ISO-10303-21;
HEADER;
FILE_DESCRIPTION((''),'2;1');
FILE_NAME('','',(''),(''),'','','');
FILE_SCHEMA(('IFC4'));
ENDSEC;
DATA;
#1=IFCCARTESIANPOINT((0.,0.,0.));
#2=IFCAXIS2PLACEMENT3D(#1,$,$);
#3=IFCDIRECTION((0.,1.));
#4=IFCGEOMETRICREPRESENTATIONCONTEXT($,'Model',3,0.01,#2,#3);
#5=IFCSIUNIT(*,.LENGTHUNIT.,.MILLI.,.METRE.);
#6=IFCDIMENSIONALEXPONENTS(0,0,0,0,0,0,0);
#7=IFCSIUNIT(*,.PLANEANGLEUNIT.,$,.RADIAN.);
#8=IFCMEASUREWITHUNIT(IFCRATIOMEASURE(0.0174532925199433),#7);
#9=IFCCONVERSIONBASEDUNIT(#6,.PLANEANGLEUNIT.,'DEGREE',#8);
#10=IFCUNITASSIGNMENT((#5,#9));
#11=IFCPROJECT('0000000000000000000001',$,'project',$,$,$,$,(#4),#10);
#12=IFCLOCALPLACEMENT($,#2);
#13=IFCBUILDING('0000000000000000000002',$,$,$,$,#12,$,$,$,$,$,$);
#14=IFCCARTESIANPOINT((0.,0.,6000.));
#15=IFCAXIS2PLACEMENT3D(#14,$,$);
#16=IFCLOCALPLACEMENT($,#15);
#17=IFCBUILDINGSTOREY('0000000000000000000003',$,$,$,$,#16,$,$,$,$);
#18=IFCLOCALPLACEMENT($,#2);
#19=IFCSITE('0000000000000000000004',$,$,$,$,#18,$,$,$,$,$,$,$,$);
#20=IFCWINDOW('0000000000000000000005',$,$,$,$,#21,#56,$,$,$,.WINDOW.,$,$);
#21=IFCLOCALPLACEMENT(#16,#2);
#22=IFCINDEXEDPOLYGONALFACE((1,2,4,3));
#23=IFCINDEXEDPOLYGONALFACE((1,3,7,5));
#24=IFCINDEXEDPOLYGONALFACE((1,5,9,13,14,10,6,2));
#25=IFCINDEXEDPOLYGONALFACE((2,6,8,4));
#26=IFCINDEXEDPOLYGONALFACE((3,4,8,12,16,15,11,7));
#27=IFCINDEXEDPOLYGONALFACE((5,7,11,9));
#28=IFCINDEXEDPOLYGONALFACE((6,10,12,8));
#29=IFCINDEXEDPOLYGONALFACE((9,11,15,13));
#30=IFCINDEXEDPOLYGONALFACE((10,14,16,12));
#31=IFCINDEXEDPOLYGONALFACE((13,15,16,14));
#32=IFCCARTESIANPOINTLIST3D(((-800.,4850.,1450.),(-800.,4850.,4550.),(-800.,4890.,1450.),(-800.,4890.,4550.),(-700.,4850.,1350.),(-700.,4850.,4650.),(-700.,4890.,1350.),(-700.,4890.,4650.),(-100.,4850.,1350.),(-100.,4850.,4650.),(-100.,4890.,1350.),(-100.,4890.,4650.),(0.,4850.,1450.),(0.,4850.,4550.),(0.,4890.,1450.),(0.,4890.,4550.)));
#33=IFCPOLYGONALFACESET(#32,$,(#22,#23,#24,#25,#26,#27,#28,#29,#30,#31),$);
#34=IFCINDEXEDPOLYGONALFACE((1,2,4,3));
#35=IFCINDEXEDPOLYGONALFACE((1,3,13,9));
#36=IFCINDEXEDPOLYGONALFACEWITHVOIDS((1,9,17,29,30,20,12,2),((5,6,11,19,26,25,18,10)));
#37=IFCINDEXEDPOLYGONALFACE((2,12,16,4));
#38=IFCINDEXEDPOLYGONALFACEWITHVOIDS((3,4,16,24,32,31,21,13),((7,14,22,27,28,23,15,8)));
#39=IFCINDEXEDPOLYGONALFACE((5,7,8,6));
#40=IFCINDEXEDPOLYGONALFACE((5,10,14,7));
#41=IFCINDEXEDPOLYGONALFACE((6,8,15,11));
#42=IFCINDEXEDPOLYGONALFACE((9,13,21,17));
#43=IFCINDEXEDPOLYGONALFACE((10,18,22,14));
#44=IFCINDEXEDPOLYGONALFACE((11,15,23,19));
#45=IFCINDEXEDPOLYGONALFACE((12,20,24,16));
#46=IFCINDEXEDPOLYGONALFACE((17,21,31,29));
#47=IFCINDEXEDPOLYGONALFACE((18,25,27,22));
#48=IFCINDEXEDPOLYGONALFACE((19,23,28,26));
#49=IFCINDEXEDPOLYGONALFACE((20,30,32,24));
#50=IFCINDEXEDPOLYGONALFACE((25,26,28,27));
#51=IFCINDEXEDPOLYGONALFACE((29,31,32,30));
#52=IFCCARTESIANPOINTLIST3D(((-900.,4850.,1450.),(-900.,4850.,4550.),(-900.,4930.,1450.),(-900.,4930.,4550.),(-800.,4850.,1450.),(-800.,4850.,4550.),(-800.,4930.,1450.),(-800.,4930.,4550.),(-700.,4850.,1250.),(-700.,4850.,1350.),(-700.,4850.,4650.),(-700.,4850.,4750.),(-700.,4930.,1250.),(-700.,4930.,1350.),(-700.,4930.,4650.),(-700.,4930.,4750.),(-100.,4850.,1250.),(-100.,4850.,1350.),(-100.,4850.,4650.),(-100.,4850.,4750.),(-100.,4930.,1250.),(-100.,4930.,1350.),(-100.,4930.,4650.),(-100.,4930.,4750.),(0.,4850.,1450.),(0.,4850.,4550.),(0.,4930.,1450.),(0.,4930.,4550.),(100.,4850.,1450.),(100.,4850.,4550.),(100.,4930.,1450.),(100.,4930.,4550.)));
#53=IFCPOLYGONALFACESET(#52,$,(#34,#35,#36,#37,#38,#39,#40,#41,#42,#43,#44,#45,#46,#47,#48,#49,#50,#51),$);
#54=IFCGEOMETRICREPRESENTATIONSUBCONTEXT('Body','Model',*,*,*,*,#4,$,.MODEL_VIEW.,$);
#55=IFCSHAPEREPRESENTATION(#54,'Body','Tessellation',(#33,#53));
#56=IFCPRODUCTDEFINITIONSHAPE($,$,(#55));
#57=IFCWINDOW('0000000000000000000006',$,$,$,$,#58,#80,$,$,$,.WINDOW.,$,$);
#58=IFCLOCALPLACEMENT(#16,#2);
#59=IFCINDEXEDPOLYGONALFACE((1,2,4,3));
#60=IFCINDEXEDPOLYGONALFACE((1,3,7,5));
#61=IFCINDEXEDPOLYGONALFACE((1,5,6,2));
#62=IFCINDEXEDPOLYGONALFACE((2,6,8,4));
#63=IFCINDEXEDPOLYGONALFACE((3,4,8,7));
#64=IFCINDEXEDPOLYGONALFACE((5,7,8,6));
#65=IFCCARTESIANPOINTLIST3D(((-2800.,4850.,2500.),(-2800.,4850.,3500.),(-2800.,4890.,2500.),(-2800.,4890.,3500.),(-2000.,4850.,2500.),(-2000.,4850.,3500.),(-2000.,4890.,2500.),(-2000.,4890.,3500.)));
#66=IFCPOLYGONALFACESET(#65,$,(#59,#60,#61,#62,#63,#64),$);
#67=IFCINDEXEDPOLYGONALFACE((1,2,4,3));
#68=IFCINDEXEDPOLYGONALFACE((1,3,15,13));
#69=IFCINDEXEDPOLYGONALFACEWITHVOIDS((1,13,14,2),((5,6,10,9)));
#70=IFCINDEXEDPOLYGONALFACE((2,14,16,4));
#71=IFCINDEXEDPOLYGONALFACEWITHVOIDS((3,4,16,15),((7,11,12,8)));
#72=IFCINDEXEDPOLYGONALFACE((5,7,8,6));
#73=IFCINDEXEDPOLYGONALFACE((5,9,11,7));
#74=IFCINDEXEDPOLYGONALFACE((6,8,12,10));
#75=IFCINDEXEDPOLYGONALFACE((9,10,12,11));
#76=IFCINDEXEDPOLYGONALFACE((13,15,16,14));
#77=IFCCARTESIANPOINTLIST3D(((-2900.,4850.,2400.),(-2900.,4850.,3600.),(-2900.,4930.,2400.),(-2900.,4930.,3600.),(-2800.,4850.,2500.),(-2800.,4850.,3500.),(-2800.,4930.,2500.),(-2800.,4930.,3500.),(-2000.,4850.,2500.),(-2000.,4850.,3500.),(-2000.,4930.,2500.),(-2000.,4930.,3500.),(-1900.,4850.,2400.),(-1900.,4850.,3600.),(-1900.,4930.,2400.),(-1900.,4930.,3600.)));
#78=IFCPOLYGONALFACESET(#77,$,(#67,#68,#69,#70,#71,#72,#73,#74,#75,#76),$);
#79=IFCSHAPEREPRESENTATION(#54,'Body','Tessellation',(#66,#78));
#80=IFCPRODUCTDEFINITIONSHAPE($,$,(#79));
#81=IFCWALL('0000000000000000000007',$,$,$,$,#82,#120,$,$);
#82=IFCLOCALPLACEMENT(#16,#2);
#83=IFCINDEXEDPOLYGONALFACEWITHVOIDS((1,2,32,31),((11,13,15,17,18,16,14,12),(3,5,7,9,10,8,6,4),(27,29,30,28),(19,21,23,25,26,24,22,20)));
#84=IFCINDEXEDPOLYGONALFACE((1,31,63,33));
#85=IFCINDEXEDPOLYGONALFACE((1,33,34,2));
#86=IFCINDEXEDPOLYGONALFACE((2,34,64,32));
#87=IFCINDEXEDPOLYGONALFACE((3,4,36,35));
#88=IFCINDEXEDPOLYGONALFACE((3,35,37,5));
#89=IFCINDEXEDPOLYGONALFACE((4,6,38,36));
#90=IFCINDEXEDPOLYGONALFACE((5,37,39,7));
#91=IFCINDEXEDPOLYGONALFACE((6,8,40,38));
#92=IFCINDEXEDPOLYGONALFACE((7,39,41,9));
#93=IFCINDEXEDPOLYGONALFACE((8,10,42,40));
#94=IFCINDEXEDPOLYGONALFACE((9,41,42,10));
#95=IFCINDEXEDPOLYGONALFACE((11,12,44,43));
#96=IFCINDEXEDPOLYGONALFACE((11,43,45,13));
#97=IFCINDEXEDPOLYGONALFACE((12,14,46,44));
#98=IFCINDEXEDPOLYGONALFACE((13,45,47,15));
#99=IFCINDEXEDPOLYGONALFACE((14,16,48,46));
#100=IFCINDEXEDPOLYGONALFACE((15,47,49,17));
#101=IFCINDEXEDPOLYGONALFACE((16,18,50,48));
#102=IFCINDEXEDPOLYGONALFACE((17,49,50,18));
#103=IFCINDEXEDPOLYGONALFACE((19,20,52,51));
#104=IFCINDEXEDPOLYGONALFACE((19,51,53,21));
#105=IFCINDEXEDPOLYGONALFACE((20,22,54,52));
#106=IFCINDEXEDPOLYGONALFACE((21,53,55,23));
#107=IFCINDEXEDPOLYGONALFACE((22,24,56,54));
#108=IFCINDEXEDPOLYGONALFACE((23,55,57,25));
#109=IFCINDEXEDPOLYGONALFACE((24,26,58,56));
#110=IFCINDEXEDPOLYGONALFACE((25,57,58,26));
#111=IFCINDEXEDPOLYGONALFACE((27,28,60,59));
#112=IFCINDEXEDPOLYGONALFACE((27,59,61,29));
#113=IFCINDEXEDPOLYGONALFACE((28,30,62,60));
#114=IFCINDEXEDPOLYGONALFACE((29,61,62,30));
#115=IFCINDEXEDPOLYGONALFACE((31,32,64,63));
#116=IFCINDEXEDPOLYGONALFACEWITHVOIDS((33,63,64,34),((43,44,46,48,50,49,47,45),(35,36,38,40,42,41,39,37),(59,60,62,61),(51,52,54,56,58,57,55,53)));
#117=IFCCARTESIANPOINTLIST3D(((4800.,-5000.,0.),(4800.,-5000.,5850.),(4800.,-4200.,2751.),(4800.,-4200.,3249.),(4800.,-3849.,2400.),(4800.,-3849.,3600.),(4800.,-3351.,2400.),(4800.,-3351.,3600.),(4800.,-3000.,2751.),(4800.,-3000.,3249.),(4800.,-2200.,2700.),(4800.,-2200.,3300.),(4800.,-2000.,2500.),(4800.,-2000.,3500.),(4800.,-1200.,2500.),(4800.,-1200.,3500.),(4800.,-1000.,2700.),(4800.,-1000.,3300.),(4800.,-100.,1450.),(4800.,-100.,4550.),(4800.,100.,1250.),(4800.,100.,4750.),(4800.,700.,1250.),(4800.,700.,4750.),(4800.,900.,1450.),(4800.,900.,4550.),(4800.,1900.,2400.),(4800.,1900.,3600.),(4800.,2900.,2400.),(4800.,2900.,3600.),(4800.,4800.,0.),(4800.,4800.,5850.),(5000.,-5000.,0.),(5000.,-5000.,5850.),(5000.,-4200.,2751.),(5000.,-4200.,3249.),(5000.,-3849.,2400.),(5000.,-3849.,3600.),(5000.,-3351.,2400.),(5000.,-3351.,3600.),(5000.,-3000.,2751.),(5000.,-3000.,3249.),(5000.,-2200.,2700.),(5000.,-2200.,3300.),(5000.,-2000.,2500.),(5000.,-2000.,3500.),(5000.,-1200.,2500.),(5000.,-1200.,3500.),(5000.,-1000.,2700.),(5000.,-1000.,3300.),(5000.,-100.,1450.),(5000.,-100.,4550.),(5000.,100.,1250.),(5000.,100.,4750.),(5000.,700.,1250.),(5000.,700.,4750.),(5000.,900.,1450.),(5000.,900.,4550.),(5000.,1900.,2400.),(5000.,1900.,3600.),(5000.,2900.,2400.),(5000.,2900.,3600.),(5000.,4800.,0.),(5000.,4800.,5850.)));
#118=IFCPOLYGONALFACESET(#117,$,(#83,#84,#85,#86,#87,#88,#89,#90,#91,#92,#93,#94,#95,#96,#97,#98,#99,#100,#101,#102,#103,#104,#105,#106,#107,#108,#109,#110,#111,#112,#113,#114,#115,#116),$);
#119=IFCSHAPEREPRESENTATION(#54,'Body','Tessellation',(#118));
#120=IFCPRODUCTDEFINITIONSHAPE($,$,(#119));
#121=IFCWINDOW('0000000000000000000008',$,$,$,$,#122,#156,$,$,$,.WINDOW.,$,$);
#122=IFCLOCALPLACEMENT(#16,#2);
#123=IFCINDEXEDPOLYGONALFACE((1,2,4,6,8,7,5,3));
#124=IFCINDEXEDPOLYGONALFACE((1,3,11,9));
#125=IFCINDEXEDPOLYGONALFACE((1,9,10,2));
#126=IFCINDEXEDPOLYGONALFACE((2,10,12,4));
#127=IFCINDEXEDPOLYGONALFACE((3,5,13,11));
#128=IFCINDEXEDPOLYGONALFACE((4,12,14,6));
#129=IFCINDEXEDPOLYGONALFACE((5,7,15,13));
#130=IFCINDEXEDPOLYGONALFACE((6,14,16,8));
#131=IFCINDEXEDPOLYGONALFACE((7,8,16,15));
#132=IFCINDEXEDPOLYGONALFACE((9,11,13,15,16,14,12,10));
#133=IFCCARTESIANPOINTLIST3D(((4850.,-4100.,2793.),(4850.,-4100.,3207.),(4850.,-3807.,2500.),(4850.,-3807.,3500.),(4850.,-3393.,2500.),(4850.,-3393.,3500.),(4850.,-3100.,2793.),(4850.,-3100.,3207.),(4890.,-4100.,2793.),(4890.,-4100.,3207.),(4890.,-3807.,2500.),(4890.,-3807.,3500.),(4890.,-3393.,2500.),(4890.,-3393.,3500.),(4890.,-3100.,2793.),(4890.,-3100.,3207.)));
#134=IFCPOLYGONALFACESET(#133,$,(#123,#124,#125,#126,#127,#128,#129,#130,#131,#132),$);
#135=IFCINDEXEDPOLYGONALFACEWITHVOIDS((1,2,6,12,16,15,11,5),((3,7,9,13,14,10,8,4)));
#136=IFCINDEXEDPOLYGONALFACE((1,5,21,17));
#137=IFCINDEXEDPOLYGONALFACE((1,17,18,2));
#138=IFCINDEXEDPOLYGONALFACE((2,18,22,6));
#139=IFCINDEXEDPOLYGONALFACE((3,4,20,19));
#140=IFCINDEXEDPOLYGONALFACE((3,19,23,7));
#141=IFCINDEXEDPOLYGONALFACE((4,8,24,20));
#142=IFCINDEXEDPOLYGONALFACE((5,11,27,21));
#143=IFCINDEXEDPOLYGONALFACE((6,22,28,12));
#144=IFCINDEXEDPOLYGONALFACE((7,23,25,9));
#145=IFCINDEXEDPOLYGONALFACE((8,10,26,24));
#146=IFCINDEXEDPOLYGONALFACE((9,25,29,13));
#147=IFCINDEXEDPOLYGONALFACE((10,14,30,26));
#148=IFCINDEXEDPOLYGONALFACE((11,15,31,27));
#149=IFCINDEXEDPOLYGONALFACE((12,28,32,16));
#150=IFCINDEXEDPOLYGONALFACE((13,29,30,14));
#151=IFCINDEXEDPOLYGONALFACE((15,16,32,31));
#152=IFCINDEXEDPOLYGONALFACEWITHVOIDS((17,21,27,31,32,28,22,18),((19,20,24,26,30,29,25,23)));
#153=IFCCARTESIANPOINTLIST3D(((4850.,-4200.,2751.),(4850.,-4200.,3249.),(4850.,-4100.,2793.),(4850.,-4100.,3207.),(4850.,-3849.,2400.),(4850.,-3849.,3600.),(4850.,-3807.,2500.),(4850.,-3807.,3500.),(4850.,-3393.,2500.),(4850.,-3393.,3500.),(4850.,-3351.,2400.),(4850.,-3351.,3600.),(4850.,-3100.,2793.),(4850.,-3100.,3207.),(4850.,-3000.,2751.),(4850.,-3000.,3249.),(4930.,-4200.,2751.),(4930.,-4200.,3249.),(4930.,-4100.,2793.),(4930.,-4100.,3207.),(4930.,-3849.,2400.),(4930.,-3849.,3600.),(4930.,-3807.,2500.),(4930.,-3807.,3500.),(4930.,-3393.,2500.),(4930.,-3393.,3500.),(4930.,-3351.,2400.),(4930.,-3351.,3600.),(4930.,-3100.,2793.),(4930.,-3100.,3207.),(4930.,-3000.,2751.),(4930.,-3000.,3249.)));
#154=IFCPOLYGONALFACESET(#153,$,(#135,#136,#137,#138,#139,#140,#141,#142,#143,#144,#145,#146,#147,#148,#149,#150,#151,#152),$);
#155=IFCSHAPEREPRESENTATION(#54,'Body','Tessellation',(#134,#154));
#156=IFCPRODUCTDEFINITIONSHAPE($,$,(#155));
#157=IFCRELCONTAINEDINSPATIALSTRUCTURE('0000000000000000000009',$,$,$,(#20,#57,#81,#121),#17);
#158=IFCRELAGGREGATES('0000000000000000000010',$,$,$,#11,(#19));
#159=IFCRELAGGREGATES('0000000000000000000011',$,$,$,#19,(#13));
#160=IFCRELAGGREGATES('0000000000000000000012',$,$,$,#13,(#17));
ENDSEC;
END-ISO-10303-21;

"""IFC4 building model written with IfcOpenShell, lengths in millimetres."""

from ifc_helpers import new_model, entity, si_unit, converted_unit, direction, frame, origin, origin_2d, place, context, subcontext, project, spatial, polyline, rectangle, outline, extrude, element, save


model = new_model("IFC4")

# Units and contexts
model_context = context("Model", 3, precision=0.01, world=origin(), true_north=direction((0.0, 1.0)))
body_context = subcontext(model_context, "Body", "Model", "MODEL_VIEW")
ifc_project = project(units=[si_unit("LENGTHUNIT", "METRE", prefix="MILLI"), converted_unit("PLANEANGLEUNIT", "DEGREE", entity("IfcRatioMeasure", 0.0174532925199433), si_unit("PLANEANGLEUNIT", "RADIAN"), dimensions=[0, 0, 0, 0, 0, 0, 0])], contexts=[model_context])

# Site, building, storey
site_placement = place(None, origin())
site = spatial("IfcSite", under=ifc_project, at=site_placement)
building_placement = place(None, origin())
building = spatial("IfcBuilding", under=site, at=building_placement)
storey_placement = place(None, frame((0.0, 0.0, 6000.0)))
storey = spatial("IfcBuildingStorey", under=building, at=storey_placement)

# Shared definitions
wall_1_placement = place(storey_placement, frame((100.0, 4900.0, 0.0), z_axis=(0.0, 0.0, 1.0), x_axis=(-1.0, 0.0, 0.0)))
window_1_placement = place(wall_1_placement, frame((500.0, 50.0, 3000.0)))
window_2_placement = place(wall_1_placement, frame((2500.0, 50.0, 3000.0)))

# Windows
cartesian_point_1 = entity("IfcCartesianPoint", [-500.0, -207.0])
shared_polyline_1 = entity("IfcPolyline", [cartesian_point_1, entity("IfcCartesianPoint", [-500.0, 207.0]), entity("IfcCartesianPoint", [-207.0, 500.0]), entity("IfcCartesianPoint", [207.0, 500.0]), entity("IfcCartesianPoint", [500.0, 207.0]), entity("IfcCartesianPoint", [500.0, -207.0]), entity("IfcCartesianPoint", [207.0, -500.0]), entity("IfcCartesianPoint", [-207.0, -500.0]), cartesian_point_1])
cartesian_point_2 = entity("IfcCartesianPoint", [-400.0, -1550.0])
shared_polyline_2 = entity("IfcPolyline", [cartesian_point_2, entity("IfcCartesianPoint", [-400.0, 1550.0]), entity("IfcCartesianPoint", [-300.0, 1650.0]), entity("IfcCartesianPoint", [300.0, 1650.0]), entity("IfcCartesianPoint", [400.0, 1550.0]), entity("IfcCartesianPoint", [400.0, -1550.0]), entity("IfcCartesianPoint", [300.0, -1650.0]), entity("IfcCartesianPoint", [-300.0, -1650.0]), cartesian_point_2])
cartesian_point_3 = entity("IfcCartesianPoint", [-500.0, -1550.0])
element("IfcWindow", 1, at=window_1_placement, inside=storey, PredefinedType="WINDOW", context=body_context, shape_type="SweptSolid", body=[
    entity("IfcExtrudedAreaSolid", entity("IfcArbitraryClosedProfileDef", "AREA", None, shared_polyline_2), entity("IfcAxis2Placement3D", entity("IfcCartesianPoint", [0.0, 0.0, 0.0]), entity("IfcDirection", [0.0, -1.0, 0.0]), entity("IfcDirection", [1.0, 0.0, 0.0])), entity("IfcDirection", [0.0, 0.0, 1.0]), 40.0),
    entity("IfcExtrudedAreaSolid", entity("IfcArbitraryProfileDefWithVoids", "AREA", None, entity("IfcPolyline", [cartesian_point_3, entity("IfcCartesianPoint", [-500.0, 1550.0]), entity("IfcCartesianPoint", [-300.0, 1750.0]), entity("IfcCartesianPoint", [300.0, 1750.0]), entity("IfcCartesianPoint", [500.0, 1550.0]), entity("IfcCartesianPoint", [500.0, -1550.0]), entity("IfcCartesianPoint", [300.0, -1750.0]), entity("IfcCartesianPoint", [-300.0, -1750.0]), cartesian_point_3]), [shared_polyline_2]), entity("IfcAxis2Placement3D", entity("IfcCartesianPoint", [0.0, 0.0, 0.0]), entity("IfcDirection", [0.0, -1.0, 0.0]), entity("IfcDirection", [1.0, 0.0, 0.0])), entity("IfcDirection", [0.0, 0.0, 1.0]), 80.0),
])
cartesian_point_4 = entity("IfcCartesianPoint", [-400.0, -500.0])
shared_polyline_3 = entity("IfcPolyline", [cartesian_point_4, entity("IfcCartesianPoint", [-400.0, 500.0]), entity("IfcCartesianPoint", [-400.0, 500.0]), entity("IfcCartesianPoint", [400.0, 500.0]), entity("IfcCartesianPoint", [400.0, 500.0]), entity("IfcCartesianPoint", [400.0, -500.0]), entity("IfcCartesianPoint", [400.0, -500.0]), entity("IfcCartesianPoint", [-400.0, -500.0]), cartesian_point_4])
cartesian_point_5 = entity("IfcCartesianPoint", [-500.0, -600.0])
element("IfcWindow", 2, at=window_2_placement, inside=storey, PredefinedType="WINDOW", context=body_context, shape_type="SweptSolid", body=[
    entity("IfcExtrudedAreaSolid", entity("IfcArbitraryClosedProfileDef", "AREA", None, shared_polyline_3), entity("IfcAxis2Placement3D", entity("IfcCartesianPoint", [0.0, 0.0, 0.0]), entity("IfcDirection", [0.0, -1.0, 0.0]), entity("IfcDirection", [1.0, 0.0, 0.0])), entity("IfcDirection", [0.0, 0.0, 1.0]), 40.0),
    entity("IfcExtrudedAreaSolid", entity("IfcArbitraryProfileDefWithVoids", "AREA", None, entity("IfcPolyline", [cartesian_point_5, entity("IfcCartesianPoint", [-500.0, 600.0]), entity("IfcCartesianPoint", [-500.0, 600.0]), entity("IfcCartesianPoint", [500.0, 600.0]), entity("IfcCartesianPoint", [500.0, 600.0]), entity("IfcCartesianPoint", [500.0, -600.0]), entity("IfcCartesianPoint", [500.0, -600.0]), entity("IfcCartesianPoint", [-500.0, -600.0]), cartesian_point_5]), [shared_polyline_3]), entity("IfcAxis2Placement3D", entity("IfcCartesianPoint", [0.0, 0.0, 0.0]), entity("IfcDirection", [0.0, -1.0, 0.0]), entity("IfcDirection", [1.0, 0.0, 0.0])), entity("IfcDirection", [0.0, 0.0, 1.0]), 80.0),
])

# Wall, openings
wall_2_placement = place(storey_placement, frame((4900.0, -100.0, 0.0), z_axis=(0.0, 0.0, 1.0), x_axis=(0.0, 1.0, 0.0)))
wall_2 = element("IfcWall", 3, at=wall_2_placement, inside=storey, context=body_context, shape_type="SweptSolid", body=[
    extrude(rectangle(XDim=9800.0, YDim=200.0, at=origin_2d()), origin(), (0.0, 0.0, 1.0), 5850.0),
])
window_3_placement = place(wall_2_placement, frame((-3500.0, 50.0, 3000.0)))
opening_1_placement = place(window_3_placement, frame((0.0, 50.0, 0.0)))
element("IfcOpeningElement", 4, at=opening_1_placement, cuts=wall_2, context=body_context, shape_type="SweptSolid", body=[
    extrude(outline(polyline([(-600.0, -249.0), (-600.0, 249.0), (-249.0, 600.0), (249.0, 600.0), (600.0, 249.0), (600.0, -249.0), (249.0, -600.0), (-249.0, -600.0), (-600.0, -249.0)])), frame((0.0, 0.0, 0.0), z_axis=(0.0, -1.0, 0.0), x_axis=(1.0, 0.0, 0.0)), (0.0, 0.0, 1.0), 200.0),
])
window_4_placement = place(wall_2_placement, frame((-1500.0, 50.0, 3000.0)))
opening_2_placement = place(window_4_placement, frame((0.0, 50.0, 0.0)))
element("IfcOpeningElement", 5, at=opening_2_placement, cuts=wall_2, context=body_context, shape_type="SweptSolid", body=[
    extrude(outline(polyline([(-600.0, -300.0), (-600.0, 300.0), (-400.0, 500.0), (400.0, 500.0), (600.0, 300.0), (600.0, -300.0), (400.0, -500.0), (-400.0, -500.0), (-600.0, -300.0)])), frame((0.0, 0.0, 0.0), z_axis=(0.0, -1.0, 0.0), x_axis=(1.0, 0.0, 0.0)), (0.0, 0.0, 1.0), 200.0),
])
window_5_placement = place(wall_2_placement, frame((500.0, 50.0, 3000.0)))
opening_3_placement = place(window_5_placement, frame((0.0, 50.0, 0.0)))
element("IfcOpeningElement", 6, at=opening_3_placement, cuts=wall_2, context=body_context, shape_type="SweptSolid", body=[
    extrude(outline(polyline([(-500.0, -1550.0), (-500.0, 1550.0), (-300.0, 1750.0), (300.0, 1750.0), (500.0, 1550.0), (500.0, -1550.0), (300.0, -1750.0), (-300.0, -1750.0), (-500.0, -1550.0)])), frame((0.0, 0.0, 0.0), z_axis=(0.0, -1.0, 0.0), x_axis=(1.0, 0.0, 0.0)), (0.0, 0.0, 1.0), 200.0),
])
window_6_placement = place(wall_2_placement, frame((2500.0, 50.0, 3000.0)))
opening_4_placement = place(window_6_placement, frame((0.0, 50.0, 0.0)))
element("IfcOpeningElement", 7, at=opening_4_placement, cuts=wall_2, context=body_context, shape_type="SweptSolid", body=[
    extrude(outline(polyline([(-500.0, -600.0), (-500.0, 600.0), (-500.0, 600.0), (500.0, 600.0), (500.0, 600.0), (500.0, -600.0), (500.0, -600.0), (-500.0, -600.0), (-500.0, -600.0)])), frame((0.0, 0.0, 0.0), z_axis=(0.0, -1.0, 0.0), x_axis=(1.0, 0.0, 0.0)), (0.0, 0.0, 1.0), 200.0),
])

# Window
cartesian_point_6 = entity("IfcCartesianPoint", [-600.0, -249.0])
element("IfcWindow", 8, at=window_3_placement, inside=storey, PredefinedType="WINDOW", context=body_context, shape_type="SweptSolid", body=[
    entity("IfcExtrudedAreaSolid", entity("IfcArbitraryClosedProfileDef", "AREA", None, shared_polyline_1), entity("IfcAxis2Placement3D", entity("IfcCartesianPoint", [0.0, 0.0, 0.0]), entity("IfcDirection", [0.0, -1.0, 0.0]), entity("IfcDirection", [1.0, 0.0, 0.0])), entity("IfcDirection", [0.0, 0.0, 1.0]), 40.0),
    entity("IfcExtrudedAreaSolid", entity("IfcArbitraryProfileDefWithVoids", "AREA", None, entity("IfcPolyline", [cartesian_point_6, entity("IfcCartesianPoint", [-600.0, 249.0]), entity("IfcCartesianPoint", [-249.0, 600.0]), entity("IfcCartesianPoint", [249.0, 600.0]), entity("IfcCartesianPoint", [600.0, 249.0]), entity("IfcCartesianPoint", [600.0, -249.0]), entity("IfcCartesianPoint", [249.0, -600.0]), entity("IfcCartesianPoint", [-249.0, -600.0]), cartesian_point_6]), [shared_polyline_1]), entity("IfcAxis2Placement3D", entity("IfcCartesianPoint", [0.0, 0.0, 0.0]), entity("IfcDirection", [0.0, -1.0, 0.0]), entity("IfcDirection", [1.0, 0.0, 0.0])), entity("IfcDirection", [0.0, 0.0, 1.0]), 80.0),
])

save(model, "model.ifc")
